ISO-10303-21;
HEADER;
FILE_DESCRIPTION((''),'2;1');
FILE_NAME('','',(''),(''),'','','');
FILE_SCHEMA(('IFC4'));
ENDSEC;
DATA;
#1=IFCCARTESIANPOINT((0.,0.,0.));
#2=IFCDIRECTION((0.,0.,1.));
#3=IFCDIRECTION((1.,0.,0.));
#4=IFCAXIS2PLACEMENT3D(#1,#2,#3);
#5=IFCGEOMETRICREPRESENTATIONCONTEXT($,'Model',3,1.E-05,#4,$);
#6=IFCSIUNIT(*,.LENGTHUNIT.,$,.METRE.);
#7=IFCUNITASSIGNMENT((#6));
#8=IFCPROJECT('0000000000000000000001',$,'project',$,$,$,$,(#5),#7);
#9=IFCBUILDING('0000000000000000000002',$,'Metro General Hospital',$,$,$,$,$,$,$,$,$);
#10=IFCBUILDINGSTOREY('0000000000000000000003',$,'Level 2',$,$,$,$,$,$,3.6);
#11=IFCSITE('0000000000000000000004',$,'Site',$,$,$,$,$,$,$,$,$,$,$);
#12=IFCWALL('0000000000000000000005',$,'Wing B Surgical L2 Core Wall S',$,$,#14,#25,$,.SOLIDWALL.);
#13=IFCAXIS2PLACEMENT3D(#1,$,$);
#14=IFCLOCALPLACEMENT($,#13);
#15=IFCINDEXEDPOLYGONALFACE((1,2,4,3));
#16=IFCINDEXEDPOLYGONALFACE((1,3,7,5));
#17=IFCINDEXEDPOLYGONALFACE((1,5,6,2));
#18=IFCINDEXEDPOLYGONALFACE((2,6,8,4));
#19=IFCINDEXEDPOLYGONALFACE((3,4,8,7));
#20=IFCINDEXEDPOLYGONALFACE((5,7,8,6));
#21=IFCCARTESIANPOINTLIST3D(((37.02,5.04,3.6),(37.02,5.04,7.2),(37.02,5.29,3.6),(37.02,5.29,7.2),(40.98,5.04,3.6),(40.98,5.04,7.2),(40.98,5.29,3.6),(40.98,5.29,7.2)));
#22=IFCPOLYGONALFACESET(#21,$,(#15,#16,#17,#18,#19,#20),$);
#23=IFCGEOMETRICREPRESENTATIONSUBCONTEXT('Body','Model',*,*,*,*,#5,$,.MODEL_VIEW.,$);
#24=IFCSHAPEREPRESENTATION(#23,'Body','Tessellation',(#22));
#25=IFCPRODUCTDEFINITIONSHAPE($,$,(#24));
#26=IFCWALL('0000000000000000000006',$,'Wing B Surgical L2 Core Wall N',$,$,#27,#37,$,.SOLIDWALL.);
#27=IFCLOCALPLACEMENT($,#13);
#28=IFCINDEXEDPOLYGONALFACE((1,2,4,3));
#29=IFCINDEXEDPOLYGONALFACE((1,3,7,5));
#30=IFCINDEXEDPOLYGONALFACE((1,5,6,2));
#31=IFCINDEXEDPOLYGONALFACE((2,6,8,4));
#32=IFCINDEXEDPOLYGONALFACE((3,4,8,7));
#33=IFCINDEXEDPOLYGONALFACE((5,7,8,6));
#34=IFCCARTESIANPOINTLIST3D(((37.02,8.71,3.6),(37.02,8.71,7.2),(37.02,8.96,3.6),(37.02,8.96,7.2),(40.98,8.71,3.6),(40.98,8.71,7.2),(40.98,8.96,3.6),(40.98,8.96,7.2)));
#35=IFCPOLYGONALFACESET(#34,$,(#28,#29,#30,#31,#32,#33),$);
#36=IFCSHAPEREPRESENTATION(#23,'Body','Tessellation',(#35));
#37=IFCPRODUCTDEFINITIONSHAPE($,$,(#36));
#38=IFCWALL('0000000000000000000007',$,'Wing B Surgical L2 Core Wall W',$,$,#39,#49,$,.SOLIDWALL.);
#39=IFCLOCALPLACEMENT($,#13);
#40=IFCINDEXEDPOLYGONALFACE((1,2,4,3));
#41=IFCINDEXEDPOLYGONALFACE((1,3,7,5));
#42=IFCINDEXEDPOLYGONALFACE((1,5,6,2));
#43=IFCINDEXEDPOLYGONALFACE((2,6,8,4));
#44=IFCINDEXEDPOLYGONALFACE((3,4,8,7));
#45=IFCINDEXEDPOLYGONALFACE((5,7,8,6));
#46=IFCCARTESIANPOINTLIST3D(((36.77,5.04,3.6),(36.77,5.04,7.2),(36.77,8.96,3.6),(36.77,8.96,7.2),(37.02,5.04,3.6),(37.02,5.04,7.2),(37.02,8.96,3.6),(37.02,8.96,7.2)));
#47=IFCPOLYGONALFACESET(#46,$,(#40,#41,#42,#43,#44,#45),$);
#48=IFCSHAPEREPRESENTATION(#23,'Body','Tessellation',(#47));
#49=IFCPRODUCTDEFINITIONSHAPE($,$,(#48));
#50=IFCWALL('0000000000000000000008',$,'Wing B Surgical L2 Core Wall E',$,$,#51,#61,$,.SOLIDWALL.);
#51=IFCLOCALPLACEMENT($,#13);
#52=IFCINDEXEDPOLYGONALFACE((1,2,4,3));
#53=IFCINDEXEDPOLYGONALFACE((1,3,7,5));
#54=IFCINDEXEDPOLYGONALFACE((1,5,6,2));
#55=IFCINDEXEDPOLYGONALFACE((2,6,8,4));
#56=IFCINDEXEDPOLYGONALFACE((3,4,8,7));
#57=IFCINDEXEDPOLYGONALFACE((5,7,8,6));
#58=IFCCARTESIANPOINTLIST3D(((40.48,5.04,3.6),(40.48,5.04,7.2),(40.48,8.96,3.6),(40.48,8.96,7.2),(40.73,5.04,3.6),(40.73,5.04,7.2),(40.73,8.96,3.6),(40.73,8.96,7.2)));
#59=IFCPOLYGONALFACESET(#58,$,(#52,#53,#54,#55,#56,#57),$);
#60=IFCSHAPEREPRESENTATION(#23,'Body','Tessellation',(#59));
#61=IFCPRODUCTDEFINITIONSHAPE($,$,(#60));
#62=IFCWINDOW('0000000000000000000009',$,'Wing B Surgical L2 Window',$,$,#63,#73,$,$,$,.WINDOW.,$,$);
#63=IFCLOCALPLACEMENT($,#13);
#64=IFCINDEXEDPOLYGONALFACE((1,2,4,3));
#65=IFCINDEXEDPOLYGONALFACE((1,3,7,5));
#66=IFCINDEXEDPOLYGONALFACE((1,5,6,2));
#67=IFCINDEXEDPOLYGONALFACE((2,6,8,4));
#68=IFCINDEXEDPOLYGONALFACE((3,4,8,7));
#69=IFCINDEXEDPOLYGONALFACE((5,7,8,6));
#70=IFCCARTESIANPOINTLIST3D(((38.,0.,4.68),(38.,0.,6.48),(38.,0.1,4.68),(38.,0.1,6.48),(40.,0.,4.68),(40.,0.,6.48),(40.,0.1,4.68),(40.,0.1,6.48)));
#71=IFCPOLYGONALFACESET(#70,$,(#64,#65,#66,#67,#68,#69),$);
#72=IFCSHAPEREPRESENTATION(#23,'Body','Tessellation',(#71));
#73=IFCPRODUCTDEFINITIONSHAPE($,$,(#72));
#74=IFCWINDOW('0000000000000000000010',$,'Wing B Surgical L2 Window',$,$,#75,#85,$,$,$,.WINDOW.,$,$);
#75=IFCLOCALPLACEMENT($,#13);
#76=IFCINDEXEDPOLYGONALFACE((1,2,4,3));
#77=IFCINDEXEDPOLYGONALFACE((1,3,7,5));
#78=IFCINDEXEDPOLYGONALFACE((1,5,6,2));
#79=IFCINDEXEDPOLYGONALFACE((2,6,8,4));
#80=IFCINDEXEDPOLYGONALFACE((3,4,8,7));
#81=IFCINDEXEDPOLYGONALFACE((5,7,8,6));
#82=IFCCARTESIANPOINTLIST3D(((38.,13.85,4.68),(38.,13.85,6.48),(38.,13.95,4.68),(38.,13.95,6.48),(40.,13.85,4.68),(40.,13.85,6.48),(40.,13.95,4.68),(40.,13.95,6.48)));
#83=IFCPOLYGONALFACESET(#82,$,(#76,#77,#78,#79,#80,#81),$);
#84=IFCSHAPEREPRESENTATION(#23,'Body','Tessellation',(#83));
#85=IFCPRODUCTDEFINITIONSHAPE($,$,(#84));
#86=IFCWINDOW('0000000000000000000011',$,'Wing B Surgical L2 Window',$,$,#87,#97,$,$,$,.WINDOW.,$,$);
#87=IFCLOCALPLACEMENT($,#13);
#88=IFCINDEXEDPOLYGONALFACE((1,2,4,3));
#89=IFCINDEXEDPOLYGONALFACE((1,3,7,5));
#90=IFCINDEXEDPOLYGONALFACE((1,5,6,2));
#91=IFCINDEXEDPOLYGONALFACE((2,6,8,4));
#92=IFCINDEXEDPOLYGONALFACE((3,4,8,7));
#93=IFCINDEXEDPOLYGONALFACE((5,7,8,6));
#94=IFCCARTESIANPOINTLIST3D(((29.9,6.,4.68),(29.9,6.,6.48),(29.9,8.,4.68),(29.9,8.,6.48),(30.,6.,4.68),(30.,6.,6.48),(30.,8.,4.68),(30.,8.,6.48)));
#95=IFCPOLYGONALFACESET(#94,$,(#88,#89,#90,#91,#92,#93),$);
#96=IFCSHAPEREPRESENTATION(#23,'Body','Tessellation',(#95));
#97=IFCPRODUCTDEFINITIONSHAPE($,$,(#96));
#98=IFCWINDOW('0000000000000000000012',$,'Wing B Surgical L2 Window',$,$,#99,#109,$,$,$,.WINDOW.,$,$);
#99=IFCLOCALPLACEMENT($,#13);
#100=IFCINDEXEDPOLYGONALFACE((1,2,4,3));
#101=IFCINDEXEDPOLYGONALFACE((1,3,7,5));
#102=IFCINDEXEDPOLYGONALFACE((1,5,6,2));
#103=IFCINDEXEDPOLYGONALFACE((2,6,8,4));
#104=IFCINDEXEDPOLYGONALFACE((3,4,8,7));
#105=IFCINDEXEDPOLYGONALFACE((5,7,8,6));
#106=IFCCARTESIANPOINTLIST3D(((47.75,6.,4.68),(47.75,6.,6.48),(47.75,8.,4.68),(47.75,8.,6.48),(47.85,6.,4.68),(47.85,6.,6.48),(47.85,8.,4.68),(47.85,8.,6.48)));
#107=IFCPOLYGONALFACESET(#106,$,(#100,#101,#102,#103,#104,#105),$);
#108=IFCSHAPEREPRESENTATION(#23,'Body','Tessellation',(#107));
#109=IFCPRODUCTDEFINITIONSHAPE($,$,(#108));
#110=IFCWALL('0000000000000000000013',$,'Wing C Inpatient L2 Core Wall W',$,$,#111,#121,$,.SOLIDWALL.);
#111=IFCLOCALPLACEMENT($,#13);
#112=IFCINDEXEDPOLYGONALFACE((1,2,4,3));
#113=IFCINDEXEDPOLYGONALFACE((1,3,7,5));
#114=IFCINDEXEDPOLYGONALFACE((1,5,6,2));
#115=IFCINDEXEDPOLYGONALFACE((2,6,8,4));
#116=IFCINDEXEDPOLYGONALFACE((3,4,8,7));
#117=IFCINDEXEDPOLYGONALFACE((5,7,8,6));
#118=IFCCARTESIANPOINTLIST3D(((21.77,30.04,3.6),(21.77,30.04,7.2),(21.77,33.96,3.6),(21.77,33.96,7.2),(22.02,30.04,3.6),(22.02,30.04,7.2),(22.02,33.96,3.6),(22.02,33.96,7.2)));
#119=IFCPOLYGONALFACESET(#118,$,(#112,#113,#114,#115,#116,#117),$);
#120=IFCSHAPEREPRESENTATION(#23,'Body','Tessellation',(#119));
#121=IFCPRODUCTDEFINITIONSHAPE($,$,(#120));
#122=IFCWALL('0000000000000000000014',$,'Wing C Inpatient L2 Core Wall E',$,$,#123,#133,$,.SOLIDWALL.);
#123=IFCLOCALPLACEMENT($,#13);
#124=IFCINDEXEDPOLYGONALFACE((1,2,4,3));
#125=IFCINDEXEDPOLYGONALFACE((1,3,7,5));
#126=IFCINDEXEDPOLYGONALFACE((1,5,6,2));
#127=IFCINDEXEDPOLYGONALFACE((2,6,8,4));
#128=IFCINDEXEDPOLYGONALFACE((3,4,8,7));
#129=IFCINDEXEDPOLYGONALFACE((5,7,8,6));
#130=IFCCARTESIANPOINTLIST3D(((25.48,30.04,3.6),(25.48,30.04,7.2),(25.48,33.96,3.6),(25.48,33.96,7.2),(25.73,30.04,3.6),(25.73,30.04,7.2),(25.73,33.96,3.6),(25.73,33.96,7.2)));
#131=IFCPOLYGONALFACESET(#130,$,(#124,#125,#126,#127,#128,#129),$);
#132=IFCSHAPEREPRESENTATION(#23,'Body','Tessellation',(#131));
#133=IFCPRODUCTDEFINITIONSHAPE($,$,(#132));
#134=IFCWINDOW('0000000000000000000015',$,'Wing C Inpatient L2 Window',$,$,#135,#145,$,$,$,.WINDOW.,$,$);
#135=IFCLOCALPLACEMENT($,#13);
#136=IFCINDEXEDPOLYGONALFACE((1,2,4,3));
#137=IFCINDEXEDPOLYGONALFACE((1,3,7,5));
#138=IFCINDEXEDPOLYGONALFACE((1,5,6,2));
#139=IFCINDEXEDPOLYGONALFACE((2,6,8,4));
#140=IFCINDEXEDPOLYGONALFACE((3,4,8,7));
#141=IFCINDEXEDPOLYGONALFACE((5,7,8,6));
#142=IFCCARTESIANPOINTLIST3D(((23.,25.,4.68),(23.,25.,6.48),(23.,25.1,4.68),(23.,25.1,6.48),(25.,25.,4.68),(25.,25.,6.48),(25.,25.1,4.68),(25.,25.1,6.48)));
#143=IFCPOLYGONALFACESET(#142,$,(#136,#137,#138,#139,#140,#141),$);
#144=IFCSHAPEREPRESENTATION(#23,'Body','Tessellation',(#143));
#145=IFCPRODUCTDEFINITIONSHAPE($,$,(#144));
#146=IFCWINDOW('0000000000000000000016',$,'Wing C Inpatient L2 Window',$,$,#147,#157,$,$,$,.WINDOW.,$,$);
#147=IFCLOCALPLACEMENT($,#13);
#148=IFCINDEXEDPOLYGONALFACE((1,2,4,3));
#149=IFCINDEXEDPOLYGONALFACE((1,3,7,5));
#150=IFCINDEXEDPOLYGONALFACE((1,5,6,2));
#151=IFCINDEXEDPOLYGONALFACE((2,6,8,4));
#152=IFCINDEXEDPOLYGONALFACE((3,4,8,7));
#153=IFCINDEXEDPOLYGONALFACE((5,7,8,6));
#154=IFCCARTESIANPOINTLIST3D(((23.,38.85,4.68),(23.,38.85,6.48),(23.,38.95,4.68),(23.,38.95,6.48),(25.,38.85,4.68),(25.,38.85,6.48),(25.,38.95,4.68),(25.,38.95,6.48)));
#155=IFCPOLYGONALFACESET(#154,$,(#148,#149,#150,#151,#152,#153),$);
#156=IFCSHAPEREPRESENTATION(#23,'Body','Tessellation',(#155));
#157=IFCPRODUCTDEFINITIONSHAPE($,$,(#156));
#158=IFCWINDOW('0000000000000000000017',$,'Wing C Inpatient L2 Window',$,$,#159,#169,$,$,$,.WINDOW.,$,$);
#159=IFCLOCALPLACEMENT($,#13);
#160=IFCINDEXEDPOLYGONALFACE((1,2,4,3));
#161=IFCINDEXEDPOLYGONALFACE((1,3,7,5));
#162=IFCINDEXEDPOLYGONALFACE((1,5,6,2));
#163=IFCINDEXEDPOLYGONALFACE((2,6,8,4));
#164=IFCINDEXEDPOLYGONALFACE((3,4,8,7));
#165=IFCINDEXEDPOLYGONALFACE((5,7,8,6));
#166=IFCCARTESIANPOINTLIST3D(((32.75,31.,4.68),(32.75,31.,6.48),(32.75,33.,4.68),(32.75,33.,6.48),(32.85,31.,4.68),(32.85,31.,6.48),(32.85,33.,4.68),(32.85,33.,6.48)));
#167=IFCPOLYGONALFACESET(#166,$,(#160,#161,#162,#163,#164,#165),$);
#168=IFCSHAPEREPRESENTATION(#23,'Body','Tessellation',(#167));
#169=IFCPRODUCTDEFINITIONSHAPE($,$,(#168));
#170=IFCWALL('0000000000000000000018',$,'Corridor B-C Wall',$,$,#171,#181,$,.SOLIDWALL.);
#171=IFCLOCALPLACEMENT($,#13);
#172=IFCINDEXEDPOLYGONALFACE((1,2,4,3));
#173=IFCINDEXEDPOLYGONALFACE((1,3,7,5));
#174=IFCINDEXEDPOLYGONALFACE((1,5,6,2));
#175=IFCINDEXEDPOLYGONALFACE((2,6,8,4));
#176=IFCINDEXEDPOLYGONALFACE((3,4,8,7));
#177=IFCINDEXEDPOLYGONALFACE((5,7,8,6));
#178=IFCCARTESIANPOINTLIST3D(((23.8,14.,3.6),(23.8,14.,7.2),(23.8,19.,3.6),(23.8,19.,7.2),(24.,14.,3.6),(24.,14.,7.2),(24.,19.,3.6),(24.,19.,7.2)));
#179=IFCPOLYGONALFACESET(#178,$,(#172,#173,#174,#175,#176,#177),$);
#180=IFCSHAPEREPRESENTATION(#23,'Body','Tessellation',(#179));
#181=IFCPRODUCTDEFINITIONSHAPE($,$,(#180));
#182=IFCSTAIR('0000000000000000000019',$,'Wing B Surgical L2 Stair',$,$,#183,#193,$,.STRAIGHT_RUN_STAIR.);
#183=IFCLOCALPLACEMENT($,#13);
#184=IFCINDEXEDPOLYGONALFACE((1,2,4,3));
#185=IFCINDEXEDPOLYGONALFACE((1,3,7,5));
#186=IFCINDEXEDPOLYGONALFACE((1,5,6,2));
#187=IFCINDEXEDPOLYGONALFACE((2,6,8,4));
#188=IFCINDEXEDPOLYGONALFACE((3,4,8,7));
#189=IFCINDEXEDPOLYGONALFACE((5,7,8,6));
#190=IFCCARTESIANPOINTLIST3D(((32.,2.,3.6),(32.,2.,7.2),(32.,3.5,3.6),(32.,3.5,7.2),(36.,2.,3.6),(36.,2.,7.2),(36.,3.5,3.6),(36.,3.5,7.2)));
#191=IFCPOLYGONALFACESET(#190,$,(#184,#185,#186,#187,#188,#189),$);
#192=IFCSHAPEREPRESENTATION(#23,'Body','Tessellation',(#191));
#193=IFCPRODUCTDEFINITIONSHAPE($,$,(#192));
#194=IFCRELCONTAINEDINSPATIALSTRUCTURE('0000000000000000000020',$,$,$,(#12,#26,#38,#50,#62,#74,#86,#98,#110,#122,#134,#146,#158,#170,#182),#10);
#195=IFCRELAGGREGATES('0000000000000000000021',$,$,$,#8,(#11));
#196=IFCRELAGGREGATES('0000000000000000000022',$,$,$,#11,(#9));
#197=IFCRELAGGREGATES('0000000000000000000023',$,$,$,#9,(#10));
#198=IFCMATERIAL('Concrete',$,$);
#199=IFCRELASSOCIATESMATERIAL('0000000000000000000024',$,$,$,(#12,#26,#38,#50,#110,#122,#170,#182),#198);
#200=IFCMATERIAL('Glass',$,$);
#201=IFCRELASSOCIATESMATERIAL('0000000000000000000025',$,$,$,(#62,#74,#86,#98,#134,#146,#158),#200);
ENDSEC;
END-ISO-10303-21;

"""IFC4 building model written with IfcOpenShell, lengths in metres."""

from ifc_helpers import new_model, si_unit, frame, origin_with_axes, place, context, subcontext, project, spatial, line, indexed_curve, outline, extrude, material, element, save


model = new_model("IFC4")

# Units and contexts
model_context = context("Model", 3, precision=1e-05, world=origin_with_axes())
body_context = subcontext(model_context, "Body", "Model", "MODEL_VIEW")
ifc_project = project(units=[si_unit("LENGTHUNIT", "METRE")], contexts=[model_context])

# Site, building, storey
site = spatial("IfcSite", under=ifc_project, Name="Site")
building = spatial("IfcBuilding", under=site, Name="Metro General Hospital")
storey = spatial("IfcBuildingStorey", under=building, Name="Level 2", Elevation=3.6)

# Shared definitions
ifc_material_1 = material(Name="Concrete")

# Walls
for number, where, z_axis, x_axis, name in (
    (1, (37.02, 5.04, 3.6), (0.0, 0.0, 1.0), (1.0, 0.0, 0.0), "Wing B Surgical L2 Core Wall S"),
    (2, (37.02, 8.71, 3.6), (0.0, 0.0, 1.0), (1.0, 0.0, 0.0), "Wing B Surgical L2 Core Wall N"),
):
    element("IfcWall", number, at=place(None, frame(where, z_axis=z_axis, x_axis=x_axis)), inside=storey, material=ifc_material_1, Name=name, PredefinedType="SOLIDWALL", context=body_context, shape_type="SweptSolid", body=[
        extrude(outline(indexed_curve([(0.0, 0.0), (3.96, 0.0), (3.96, 0.25), (0.0, 0.25)], segments=[line(1, 2, 3, 4, 1)])), origin_with_axes(), (0.0, 0.0, 1.0), 3.6),
    ])
for number, where, z_axis, x_axis, name in (
    (3, (37.02, 5.04, 3.6), (0.0, 0.0, 1.0), (0.0, 1.0, 0.0), "Wing B Surgical L2 Core Wall W"),
    (4, (40.73, 5.04, 3.6), (0.0, 0.0, 1.0), (0.0, 1.0, 0.0), "Wing B Surgical L2 Core Wall E"),
):
    element("IfcWall", number, at=place(None, frame(where, z_axis=z_axis, x_axis=x_axis)), inside=storey, material=ifc_material_1, Name=name, PredefinedType="SOLIDWALL", context=body_context, shape_type="SweptSolid", body=[
        extrude(outline(indexed_curve([(0.0, 0.0), (3.92, 0.0), (3.92, 0.25), (0.0, 0.25)], segments=[line(1, 2, 3, 4, 1)])), origin_with_axes(), (0.0, 0.0, 1.0), 3.6),
    ])

# Windows
ifc_material_2 = material(Name="Glass")
for number, where, z_axis, x_axis, name in (
    (5, (38.0, 0.0, 4.68), (0.0, 0.0, 1.0), (1.0, 0.0, 0.0), "Wing B Surgical L2 Window"),
    (6, (38.0, 13.85, 4.68), (0.0, 0.0, 1.0), (1.0, 0.0, 0.0), "Wing B Surgical L2 Window"),
    (7, (30.0, 6.0, 4.68), (0.0, 0.0, 1.0), (0.0, 1.0, 0.0), "Wing B Surgical L2 Window"),
    (8, (47.85, 6.0, 4.68), (0.0, 0.0, 1.0), (0.0, 1.0, 0.0), "Wing B Surgical L2 Window"),
):
    element("IfcWindow", number, at=place(None, frame(where, z_axis=z_axis, x_axis=x_axis)), inside=storey, material=ifc_material_2, Name=name, PredefinedType="WINDOW", context=body_context, shape_type="SweptSolid", body=[
        extrude(outline(indexed_curve([(0.0, 0.0), (2.0, 0.0), (2.0, 0.1), (0.0, 0.1)], segments=[line(1, 2, 3, 4, 1)])), origin_with_axes(), (0.0, 0.0, 1.0), 1.8),
    ])

# Walls
for number, where, z_axis, x_axis, name in (
    (9, (22.02, 30.04, 3.6), (0.0, 0.0, 1.0), (0.0, 1.0, 0.0), "Wing C Inpatient L2 Core Wall W"),
    (10, (25.73, 30.04, 3.6), (0.0, 0.0, 1.0), (0.0, 1.0, 0.0), "Wing C Inpatient L2 Core Wall E"),
):
    element("IfcWall", number, at=place(None, frame(where, z_axis=z_axis, x_axis=x_axis)), inside=storey, material=ifc_material_1, Name=name, PredefinedType="SOLIDWALL", context=body_context, shape_type="SweptSolid", body=[
        extrude(outline(indexed_curve([(0.0, 0.0), (3.92, 0.0), (3.92, 0.25), (0.0, 0.25)], segments=[line(1, 2, 3, 4, 1)])), origin_with_axes(), (0.0, 0.0, 1.0), 3.6),
    ])

# Windows
for number, where, z_axis, x_axis, name in (
    (11, (23.0, 25.0, 4.68), (0.0, 0.0, 1.0), (1.0, 0.0, 0.0), "Wing C Inpatient L2 Window"),
    (12, (23.0, 38.85, 4.68), (0.0, 0.0, 1.0), (1.0, 0.0, 0.0), "Wing C Inpatient L2 Window"),
    (13, (32.85, 31.0, 4.68), (0.0, 0.0, 1.0), (0.0, 1.0, 0.0), "Wing C Inpatient L2 Window"),
):
    element("IfcWindow", number, at=place(None, frame(where, z_axis=z_axis, x_axis=x_axis)), inside=storey, material=ifc_material_2, Name=name, PredefinedType="WINDOW", context=body_context, shape_type="SweptSolid", body=[
        extrude(outline(indexed_curve([(0.0, 0.0), (2.0, 0.0), (2.0, 0.1), (0.0, 0.1)], segments=[line(1, 2, 3, 4, 1)])), origin_with_axes(), (0.0, 0.0, 1.0), 1.8),
    ])

# Wall
wall_placement = place(None, frame((24.0, 14.0, 3.6), z_axis=(0.0, 0.0, 1.0), x_axis=(0.0, 1.0, 0.0)))
element("IfcWall", 14, at=wall_placement, inside=storey, material=ifc_material_1, Name="Corridor B-C Wall", PredefinedType="SOLIDWALL", context=body_context, shape_type="SweptSolid", body=[
    extrude(outline(indexed_curve([(0.0, 0.0), (5.0, 0.0), (5.0, 0.2), (0.0, 0.2)], segments=[line(1, 2, 3, 4, 1)])), origin_with_axes(), (0.0, 0.0, 1.0), 3.6),
])

# Stair
stair_placement = place(None, frame((32.0, 2.0, 3.6), z_axis=(0.0, 0.0, 1.0), x_axis=(1.0, 0.0, 0.0)))
element("IfcStair", 15, at=stair_placement, inside=storey, material=ifc_material_1, Name="Wing B Surgical L2 Stair", PredefinedType="STRAIGHT_RUN_STAIR", context=body_context, shape_type="SweptSolid", body=[
    extrude(outline(indexed_curve([(0.0, 0.0), (4.0, 0.0), (4.0, 1.5), (0.0, 1.5)], segments=[line(1, 2, 3, 4, 1)])), origin_with_axes(), (0.0, 0.0, 1.0), 3.6),
])

save(model, "model.ifc")
